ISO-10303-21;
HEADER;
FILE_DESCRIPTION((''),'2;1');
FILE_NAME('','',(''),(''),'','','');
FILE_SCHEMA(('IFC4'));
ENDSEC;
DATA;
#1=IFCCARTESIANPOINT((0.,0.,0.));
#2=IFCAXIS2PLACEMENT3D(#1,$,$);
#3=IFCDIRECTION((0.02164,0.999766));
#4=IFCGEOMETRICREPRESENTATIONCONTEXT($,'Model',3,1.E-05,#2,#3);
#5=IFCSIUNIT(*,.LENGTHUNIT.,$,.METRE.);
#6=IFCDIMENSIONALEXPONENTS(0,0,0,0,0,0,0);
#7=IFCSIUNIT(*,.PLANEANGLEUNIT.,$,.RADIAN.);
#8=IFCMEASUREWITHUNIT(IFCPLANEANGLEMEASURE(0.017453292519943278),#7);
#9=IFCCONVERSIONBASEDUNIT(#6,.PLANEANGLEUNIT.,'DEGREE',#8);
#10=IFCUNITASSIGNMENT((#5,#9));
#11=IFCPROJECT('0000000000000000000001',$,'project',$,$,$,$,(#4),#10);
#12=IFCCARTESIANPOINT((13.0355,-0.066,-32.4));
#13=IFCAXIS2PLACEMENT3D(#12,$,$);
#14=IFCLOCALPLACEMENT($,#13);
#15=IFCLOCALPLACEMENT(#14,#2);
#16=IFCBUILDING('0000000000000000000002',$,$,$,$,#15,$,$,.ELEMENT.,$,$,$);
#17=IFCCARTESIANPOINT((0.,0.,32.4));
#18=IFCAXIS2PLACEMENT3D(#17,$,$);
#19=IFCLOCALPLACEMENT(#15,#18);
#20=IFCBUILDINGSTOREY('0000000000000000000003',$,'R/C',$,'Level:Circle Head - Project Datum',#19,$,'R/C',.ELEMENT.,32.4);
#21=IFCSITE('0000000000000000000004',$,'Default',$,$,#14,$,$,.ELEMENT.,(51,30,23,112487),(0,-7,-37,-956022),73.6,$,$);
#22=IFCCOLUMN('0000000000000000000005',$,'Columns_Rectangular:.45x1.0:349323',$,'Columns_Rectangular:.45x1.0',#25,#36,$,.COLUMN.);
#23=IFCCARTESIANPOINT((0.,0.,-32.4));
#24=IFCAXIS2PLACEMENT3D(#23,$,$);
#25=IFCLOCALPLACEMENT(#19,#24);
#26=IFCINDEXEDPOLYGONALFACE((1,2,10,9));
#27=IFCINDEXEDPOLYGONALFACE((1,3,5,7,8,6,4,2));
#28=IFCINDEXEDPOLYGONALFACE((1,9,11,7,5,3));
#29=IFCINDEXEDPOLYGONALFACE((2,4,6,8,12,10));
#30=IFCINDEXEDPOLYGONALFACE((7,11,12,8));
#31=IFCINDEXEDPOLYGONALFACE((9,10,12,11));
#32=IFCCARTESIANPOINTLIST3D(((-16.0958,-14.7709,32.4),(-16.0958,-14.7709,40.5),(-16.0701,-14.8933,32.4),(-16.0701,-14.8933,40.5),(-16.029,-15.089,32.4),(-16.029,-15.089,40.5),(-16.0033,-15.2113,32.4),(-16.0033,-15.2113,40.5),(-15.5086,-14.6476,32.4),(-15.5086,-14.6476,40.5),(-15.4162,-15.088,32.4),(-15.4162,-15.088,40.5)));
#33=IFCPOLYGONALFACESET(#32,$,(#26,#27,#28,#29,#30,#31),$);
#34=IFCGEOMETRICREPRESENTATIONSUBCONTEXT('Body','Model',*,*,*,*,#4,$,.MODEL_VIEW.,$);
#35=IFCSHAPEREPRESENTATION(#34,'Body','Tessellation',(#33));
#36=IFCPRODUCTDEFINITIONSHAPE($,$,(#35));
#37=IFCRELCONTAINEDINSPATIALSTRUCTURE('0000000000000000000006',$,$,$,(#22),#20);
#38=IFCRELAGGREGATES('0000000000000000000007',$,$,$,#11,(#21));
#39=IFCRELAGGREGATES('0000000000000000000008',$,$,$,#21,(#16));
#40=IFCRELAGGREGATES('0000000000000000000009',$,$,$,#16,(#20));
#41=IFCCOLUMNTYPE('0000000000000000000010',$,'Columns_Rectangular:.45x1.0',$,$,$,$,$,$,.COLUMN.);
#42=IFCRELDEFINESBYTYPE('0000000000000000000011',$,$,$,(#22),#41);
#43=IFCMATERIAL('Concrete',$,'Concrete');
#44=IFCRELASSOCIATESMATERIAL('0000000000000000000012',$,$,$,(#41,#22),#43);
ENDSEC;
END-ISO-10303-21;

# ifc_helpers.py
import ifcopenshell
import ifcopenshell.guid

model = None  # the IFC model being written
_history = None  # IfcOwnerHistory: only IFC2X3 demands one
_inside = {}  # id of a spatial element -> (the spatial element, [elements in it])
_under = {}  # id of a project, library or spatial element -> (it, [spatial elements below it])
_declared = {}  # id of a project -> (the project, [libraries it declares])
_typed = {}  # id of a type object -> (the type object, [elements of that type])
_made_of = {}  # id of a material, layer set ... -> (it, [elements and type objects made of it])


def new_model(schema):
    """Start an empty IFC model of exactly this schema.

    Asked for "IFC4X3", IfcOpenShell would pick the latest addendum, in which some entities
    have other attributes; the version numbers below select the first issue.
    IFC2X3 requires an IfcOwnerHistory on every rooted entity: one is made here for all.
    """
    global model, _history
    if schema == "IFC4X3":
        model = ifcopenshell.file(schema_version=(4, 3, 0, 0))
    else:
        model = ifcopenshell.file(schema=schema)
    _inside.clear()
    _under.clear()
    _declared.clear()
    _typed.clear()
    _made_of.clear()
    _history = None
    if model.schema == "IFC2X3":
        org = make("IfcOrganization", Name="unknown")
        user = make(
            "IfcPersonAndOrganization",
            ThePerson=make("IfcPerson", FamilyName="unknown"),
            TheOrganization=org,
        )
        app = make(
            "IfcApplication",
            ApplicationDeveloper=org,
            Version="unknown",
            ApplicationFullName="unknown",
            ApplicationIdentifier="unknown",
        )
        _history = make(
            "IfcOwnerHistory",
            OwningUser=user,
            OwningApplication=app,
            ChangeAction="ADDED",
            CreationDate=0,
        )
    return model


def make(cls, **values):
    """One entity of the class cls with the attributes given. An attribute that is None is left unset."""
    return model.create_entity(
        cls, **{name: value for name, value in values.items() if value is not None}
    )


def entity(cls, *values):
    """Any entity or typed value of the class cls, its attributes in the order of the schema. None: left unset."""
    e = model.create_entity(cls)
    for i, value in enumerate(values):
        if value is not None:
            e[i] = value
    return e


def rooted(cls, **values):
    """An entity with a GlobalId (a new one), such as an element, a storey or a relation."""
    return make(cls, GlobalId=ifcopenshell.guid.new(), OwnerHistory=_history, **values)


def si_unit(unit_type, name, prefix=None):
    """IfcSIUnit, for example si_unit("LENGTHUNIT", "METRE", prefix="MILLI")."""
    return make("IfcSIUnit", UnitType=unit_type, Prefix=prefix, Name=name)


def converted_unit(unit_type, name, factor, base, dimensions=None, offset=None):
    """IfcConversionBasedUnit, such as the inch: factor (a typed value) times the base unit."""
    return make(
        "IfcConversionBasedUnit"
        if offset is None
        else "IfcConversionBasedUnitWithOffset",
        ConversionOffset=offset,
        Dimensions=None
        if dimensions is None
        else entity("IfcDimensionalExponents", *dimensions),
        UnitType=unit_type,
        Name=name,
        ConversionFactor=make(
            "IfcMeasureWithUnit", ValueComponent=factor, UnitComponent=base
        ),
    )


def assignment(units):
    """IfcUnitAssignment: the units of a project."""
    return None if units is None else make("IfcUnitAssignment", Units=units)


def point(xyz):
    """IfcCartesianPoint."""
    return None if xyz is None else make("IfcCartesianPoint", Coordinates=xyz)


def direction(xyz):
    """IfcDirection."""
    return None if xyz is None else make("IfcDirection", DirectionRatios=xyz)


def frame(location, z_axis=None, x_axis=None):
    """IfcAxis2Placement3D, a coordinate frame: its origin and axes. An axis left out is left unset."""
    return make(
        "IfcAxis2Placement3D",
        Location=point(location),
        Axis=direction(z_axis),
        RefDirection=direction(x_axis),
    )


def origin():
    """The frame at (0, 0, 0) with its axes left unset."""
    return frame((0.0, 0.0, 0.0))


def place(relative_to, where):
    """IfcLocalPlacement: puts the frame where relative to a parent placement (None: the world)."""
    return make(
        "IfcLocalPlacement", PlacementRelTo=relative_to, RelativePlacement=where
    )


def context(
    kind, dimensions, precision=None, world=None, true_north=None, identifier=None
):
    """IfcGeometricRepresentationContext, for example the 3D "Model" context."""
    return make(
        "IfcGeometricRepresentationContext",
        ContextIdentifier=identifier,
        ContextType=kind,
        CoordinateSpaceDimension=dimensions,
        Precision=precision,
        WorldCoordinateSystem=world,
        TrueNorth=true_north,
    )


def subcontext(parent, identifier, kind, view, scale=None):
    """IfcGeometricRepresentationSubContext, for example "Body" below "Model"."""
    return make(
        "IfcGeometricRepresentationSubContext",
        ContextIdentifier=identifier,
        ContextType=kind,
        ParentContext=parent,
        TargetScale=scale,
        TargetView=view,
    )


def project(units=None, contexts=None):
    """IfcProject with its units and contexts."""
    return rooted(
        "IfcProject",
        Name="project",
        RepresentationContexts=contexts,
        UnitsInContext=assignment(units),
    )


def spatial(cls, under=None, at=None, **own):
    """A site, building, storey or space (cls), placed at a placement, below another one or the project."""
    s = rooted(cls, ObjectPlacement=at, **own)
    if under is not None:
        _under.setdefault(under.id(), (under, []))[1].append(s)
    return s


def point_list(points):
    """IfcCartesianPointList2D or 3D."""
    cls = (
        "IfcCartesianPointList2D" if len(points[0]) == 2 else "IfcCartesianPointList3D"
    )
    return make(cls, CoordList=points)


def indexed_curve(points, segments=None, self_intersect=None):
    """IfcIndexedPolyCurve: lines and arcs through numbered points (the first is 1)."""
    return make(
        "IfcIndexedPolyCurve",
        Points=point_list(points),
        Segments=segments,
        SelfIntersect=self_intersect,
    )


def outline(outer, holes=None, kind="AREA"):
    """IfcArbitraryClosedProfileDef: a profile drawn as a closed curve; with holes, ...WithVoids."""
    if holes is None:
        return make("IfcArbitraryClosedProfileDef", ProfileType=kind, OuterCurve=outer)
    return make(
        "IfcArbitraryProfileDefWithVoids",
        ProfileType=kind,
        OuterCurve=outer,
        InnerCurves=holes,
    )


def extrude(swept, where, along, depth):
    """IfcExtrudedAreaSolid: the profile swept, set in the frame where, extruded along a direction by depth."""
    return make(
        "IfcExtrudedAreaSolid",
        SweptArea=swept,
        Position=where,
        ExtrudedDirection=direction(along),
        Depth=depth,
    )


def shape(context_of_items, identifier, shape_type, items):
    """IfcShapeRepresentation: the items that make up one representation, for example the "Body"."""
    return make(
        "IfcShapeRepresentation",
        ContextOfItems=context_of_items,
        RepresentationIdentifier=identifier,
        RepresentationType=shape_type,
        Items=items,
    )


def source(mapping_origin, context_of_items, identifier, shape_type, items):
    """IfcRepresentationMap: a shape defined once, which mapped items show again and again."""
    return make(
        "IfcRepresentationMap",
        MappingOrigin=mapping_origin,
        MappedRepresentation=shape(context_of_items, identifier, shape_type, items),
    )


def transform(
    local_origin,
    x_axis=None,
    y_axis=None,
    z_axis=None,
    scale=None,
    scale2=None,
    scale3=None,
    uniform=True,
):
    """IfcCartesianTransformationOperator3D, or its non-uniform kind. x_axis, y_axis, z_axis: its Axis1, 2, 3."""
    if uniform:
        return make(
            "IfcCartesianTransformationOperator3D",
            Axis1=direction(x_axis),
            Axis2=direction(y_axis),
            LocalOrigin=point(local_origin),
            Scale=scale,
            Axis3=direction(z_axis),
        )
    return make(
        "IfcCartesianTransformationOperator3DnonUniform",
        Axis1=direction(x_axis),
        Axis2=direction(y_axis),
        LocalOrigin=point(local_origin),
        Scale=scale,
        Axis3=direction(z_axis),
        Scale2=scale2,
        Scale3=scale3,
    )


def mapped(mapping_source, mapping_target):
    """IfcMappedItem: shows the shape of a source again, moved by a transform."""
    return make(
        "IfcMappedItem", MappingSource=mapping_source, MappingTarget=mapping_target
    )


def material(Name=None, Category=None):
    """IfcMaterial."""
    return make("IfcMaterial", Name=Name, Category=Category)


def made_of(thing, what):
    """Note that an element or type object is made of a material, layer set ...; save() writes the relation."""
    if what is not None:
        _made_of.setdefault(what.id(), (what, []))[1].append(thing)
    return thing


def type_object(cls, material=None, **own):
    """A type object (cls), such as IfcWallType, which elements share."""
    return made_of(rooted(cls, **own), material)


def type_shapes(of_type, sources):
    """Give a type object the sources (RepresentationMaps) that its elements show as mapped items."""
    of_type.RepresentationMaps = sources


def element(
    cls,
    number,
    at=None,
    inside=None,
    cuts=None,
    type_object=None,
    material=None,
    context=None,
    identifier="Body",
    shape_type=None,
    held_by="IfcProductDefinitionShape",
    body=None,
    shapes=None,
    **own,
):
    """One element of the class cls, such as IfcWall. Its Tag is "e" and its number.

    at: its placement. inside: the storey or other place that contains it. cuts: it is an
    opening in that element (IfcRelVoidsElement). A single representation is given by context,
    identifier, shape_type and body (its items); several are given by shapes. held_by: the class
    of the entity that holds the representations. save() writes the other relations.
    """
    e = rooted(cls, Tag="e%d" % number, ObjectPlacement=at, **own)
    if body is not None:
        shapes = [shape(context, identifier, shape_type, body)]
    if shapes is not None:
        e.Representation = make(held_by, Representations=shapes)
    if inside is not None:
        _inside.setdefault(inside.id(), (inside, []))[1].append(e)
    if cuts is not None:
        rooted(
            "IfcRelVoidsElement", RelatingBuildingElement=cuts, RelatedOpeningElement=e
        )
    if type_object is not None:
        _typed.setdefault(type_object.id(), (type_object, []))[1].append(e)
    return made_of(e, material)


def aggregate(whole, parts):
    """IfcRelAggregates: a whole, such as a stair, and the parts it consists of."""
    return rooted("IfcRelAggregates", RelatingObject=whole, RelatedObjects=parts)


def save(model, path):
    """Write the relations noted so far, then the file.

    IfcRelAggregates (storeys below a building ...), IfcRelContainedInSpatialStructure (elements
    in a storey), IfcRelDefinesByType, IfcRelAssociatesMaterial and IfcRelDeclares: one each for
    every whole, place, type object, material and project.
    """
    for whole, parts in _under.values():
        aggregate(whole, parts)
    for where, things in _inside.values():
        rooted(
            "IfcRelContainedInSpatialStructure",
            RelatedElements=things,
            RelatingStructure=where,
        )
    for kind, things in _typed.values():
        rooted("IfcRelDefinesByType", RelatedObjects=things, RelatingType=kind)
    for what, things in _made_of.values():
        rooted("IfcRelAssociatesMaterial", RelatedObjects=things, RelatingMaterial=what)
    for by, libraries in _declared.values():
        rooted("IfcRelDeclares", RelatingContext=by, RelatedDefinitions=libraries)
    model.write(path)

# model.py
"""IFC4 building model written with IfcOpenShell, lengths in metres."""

from ifc_helpers import new_model, entity, si_unit, converted_unit, direction, frame, origin, place, context, subcontext, project, spatial, indexed_curve, outline, extrude, source, transform, mapped, material, type_object, type_shapes, element, save


model = new_model("IFC4")

# Units and contexts
model_context = context("Model", 3, precision=1e-05, world=origin(), true_north=direction((0.02164, 0.999766)))
body_context = subcontext(model_context, "Body", "Model", "MODEL_VIEW")
ifc_project = project(units=[si_unit("LENGTHUNIT", "METRE"), converted_unit("PLANEANGLEUNIT", "DEGREE", entity("IfcPlaneAngleMeasure", 0.017453292519943278), si_unit("PLANEANGLEUNIT", "RADIAN"), dimensions=[0, 0, 0, 0, 0, 0, 0])], contexts=[model_context])

# Site, building, storey
site_placement = place(None, frame((13.0355, -0.066, -32.4)))
site = spatial("IfcSite", under=ifc_project, at=site_placement, Name="Default", CompositionType="ELEMENT", RefLatitude=(51, 30, 23, 112487), RefLongitude=(0, -7, -37, -956022), RefElevation=73.6)
building_placement = place(site_placement, origin())
building = spatial("IfcBuilding", under=site, at=building_placement, CompositionType="ELEMENT")
storey_placement = place(building_placement, frame((0.0, 0.0, 32.4)))
storey = spatial("IfcBuildingStorey", under=building, at=storey_placement, Name="R/C", ObjectType="Level:Circle Head - Project Datum", LongName="R/C", CompositionType="ELEMENT", Elevation=32.4)

# Column
ifc_material = material(Name="Concrete", Category="Concrete")
column_type_1 = type_object("IfcColumnType", Name="Columns_Rectangular:.45x1.0", PredefinedType="COLUMN", material=ifc_material)
shared_shape_1 = source(origin(), body_context, "Body", "SweptSolid", [
    extrude(outline(indexed_curve([(-0.225, -0.4), (0.225, -0.4), (0.225, 0.2), (0.1, 0.2), (-0.1, 0.2), (-0.225, 0.2), (-0.225, -0.4)], self_intersect=False)), frame((-15.8539, -14.95, 32.4), z_axis=(0.0, 0.0, 1.0), x_axis=(-0.2055, 0.978657, 0.0)), (0.0, 0.0, 1.0), 8.1),
])
type_shapes(column_type_1, [shared_shape_1])
column_1_placement = place(storey_placement, frame((0.0, 0.0, -32.4)))
element("IfcColumn", 1, at=column_1_placement, inside=storey, type_object=column_type_1, material=ifc_material, Name="Columns_Rectangular:.45x1.0:349323", ObjectType="Columns_Rectangular:.45x1.0", PredefinedType="COLUMN", context=body_context, shape_type="MappedRepresentation", body=[
    mapped(shared_shape_1, transform((0.0, 0.0, 0.0), scale=1.0)),
])

save(model, "model.ifc")
